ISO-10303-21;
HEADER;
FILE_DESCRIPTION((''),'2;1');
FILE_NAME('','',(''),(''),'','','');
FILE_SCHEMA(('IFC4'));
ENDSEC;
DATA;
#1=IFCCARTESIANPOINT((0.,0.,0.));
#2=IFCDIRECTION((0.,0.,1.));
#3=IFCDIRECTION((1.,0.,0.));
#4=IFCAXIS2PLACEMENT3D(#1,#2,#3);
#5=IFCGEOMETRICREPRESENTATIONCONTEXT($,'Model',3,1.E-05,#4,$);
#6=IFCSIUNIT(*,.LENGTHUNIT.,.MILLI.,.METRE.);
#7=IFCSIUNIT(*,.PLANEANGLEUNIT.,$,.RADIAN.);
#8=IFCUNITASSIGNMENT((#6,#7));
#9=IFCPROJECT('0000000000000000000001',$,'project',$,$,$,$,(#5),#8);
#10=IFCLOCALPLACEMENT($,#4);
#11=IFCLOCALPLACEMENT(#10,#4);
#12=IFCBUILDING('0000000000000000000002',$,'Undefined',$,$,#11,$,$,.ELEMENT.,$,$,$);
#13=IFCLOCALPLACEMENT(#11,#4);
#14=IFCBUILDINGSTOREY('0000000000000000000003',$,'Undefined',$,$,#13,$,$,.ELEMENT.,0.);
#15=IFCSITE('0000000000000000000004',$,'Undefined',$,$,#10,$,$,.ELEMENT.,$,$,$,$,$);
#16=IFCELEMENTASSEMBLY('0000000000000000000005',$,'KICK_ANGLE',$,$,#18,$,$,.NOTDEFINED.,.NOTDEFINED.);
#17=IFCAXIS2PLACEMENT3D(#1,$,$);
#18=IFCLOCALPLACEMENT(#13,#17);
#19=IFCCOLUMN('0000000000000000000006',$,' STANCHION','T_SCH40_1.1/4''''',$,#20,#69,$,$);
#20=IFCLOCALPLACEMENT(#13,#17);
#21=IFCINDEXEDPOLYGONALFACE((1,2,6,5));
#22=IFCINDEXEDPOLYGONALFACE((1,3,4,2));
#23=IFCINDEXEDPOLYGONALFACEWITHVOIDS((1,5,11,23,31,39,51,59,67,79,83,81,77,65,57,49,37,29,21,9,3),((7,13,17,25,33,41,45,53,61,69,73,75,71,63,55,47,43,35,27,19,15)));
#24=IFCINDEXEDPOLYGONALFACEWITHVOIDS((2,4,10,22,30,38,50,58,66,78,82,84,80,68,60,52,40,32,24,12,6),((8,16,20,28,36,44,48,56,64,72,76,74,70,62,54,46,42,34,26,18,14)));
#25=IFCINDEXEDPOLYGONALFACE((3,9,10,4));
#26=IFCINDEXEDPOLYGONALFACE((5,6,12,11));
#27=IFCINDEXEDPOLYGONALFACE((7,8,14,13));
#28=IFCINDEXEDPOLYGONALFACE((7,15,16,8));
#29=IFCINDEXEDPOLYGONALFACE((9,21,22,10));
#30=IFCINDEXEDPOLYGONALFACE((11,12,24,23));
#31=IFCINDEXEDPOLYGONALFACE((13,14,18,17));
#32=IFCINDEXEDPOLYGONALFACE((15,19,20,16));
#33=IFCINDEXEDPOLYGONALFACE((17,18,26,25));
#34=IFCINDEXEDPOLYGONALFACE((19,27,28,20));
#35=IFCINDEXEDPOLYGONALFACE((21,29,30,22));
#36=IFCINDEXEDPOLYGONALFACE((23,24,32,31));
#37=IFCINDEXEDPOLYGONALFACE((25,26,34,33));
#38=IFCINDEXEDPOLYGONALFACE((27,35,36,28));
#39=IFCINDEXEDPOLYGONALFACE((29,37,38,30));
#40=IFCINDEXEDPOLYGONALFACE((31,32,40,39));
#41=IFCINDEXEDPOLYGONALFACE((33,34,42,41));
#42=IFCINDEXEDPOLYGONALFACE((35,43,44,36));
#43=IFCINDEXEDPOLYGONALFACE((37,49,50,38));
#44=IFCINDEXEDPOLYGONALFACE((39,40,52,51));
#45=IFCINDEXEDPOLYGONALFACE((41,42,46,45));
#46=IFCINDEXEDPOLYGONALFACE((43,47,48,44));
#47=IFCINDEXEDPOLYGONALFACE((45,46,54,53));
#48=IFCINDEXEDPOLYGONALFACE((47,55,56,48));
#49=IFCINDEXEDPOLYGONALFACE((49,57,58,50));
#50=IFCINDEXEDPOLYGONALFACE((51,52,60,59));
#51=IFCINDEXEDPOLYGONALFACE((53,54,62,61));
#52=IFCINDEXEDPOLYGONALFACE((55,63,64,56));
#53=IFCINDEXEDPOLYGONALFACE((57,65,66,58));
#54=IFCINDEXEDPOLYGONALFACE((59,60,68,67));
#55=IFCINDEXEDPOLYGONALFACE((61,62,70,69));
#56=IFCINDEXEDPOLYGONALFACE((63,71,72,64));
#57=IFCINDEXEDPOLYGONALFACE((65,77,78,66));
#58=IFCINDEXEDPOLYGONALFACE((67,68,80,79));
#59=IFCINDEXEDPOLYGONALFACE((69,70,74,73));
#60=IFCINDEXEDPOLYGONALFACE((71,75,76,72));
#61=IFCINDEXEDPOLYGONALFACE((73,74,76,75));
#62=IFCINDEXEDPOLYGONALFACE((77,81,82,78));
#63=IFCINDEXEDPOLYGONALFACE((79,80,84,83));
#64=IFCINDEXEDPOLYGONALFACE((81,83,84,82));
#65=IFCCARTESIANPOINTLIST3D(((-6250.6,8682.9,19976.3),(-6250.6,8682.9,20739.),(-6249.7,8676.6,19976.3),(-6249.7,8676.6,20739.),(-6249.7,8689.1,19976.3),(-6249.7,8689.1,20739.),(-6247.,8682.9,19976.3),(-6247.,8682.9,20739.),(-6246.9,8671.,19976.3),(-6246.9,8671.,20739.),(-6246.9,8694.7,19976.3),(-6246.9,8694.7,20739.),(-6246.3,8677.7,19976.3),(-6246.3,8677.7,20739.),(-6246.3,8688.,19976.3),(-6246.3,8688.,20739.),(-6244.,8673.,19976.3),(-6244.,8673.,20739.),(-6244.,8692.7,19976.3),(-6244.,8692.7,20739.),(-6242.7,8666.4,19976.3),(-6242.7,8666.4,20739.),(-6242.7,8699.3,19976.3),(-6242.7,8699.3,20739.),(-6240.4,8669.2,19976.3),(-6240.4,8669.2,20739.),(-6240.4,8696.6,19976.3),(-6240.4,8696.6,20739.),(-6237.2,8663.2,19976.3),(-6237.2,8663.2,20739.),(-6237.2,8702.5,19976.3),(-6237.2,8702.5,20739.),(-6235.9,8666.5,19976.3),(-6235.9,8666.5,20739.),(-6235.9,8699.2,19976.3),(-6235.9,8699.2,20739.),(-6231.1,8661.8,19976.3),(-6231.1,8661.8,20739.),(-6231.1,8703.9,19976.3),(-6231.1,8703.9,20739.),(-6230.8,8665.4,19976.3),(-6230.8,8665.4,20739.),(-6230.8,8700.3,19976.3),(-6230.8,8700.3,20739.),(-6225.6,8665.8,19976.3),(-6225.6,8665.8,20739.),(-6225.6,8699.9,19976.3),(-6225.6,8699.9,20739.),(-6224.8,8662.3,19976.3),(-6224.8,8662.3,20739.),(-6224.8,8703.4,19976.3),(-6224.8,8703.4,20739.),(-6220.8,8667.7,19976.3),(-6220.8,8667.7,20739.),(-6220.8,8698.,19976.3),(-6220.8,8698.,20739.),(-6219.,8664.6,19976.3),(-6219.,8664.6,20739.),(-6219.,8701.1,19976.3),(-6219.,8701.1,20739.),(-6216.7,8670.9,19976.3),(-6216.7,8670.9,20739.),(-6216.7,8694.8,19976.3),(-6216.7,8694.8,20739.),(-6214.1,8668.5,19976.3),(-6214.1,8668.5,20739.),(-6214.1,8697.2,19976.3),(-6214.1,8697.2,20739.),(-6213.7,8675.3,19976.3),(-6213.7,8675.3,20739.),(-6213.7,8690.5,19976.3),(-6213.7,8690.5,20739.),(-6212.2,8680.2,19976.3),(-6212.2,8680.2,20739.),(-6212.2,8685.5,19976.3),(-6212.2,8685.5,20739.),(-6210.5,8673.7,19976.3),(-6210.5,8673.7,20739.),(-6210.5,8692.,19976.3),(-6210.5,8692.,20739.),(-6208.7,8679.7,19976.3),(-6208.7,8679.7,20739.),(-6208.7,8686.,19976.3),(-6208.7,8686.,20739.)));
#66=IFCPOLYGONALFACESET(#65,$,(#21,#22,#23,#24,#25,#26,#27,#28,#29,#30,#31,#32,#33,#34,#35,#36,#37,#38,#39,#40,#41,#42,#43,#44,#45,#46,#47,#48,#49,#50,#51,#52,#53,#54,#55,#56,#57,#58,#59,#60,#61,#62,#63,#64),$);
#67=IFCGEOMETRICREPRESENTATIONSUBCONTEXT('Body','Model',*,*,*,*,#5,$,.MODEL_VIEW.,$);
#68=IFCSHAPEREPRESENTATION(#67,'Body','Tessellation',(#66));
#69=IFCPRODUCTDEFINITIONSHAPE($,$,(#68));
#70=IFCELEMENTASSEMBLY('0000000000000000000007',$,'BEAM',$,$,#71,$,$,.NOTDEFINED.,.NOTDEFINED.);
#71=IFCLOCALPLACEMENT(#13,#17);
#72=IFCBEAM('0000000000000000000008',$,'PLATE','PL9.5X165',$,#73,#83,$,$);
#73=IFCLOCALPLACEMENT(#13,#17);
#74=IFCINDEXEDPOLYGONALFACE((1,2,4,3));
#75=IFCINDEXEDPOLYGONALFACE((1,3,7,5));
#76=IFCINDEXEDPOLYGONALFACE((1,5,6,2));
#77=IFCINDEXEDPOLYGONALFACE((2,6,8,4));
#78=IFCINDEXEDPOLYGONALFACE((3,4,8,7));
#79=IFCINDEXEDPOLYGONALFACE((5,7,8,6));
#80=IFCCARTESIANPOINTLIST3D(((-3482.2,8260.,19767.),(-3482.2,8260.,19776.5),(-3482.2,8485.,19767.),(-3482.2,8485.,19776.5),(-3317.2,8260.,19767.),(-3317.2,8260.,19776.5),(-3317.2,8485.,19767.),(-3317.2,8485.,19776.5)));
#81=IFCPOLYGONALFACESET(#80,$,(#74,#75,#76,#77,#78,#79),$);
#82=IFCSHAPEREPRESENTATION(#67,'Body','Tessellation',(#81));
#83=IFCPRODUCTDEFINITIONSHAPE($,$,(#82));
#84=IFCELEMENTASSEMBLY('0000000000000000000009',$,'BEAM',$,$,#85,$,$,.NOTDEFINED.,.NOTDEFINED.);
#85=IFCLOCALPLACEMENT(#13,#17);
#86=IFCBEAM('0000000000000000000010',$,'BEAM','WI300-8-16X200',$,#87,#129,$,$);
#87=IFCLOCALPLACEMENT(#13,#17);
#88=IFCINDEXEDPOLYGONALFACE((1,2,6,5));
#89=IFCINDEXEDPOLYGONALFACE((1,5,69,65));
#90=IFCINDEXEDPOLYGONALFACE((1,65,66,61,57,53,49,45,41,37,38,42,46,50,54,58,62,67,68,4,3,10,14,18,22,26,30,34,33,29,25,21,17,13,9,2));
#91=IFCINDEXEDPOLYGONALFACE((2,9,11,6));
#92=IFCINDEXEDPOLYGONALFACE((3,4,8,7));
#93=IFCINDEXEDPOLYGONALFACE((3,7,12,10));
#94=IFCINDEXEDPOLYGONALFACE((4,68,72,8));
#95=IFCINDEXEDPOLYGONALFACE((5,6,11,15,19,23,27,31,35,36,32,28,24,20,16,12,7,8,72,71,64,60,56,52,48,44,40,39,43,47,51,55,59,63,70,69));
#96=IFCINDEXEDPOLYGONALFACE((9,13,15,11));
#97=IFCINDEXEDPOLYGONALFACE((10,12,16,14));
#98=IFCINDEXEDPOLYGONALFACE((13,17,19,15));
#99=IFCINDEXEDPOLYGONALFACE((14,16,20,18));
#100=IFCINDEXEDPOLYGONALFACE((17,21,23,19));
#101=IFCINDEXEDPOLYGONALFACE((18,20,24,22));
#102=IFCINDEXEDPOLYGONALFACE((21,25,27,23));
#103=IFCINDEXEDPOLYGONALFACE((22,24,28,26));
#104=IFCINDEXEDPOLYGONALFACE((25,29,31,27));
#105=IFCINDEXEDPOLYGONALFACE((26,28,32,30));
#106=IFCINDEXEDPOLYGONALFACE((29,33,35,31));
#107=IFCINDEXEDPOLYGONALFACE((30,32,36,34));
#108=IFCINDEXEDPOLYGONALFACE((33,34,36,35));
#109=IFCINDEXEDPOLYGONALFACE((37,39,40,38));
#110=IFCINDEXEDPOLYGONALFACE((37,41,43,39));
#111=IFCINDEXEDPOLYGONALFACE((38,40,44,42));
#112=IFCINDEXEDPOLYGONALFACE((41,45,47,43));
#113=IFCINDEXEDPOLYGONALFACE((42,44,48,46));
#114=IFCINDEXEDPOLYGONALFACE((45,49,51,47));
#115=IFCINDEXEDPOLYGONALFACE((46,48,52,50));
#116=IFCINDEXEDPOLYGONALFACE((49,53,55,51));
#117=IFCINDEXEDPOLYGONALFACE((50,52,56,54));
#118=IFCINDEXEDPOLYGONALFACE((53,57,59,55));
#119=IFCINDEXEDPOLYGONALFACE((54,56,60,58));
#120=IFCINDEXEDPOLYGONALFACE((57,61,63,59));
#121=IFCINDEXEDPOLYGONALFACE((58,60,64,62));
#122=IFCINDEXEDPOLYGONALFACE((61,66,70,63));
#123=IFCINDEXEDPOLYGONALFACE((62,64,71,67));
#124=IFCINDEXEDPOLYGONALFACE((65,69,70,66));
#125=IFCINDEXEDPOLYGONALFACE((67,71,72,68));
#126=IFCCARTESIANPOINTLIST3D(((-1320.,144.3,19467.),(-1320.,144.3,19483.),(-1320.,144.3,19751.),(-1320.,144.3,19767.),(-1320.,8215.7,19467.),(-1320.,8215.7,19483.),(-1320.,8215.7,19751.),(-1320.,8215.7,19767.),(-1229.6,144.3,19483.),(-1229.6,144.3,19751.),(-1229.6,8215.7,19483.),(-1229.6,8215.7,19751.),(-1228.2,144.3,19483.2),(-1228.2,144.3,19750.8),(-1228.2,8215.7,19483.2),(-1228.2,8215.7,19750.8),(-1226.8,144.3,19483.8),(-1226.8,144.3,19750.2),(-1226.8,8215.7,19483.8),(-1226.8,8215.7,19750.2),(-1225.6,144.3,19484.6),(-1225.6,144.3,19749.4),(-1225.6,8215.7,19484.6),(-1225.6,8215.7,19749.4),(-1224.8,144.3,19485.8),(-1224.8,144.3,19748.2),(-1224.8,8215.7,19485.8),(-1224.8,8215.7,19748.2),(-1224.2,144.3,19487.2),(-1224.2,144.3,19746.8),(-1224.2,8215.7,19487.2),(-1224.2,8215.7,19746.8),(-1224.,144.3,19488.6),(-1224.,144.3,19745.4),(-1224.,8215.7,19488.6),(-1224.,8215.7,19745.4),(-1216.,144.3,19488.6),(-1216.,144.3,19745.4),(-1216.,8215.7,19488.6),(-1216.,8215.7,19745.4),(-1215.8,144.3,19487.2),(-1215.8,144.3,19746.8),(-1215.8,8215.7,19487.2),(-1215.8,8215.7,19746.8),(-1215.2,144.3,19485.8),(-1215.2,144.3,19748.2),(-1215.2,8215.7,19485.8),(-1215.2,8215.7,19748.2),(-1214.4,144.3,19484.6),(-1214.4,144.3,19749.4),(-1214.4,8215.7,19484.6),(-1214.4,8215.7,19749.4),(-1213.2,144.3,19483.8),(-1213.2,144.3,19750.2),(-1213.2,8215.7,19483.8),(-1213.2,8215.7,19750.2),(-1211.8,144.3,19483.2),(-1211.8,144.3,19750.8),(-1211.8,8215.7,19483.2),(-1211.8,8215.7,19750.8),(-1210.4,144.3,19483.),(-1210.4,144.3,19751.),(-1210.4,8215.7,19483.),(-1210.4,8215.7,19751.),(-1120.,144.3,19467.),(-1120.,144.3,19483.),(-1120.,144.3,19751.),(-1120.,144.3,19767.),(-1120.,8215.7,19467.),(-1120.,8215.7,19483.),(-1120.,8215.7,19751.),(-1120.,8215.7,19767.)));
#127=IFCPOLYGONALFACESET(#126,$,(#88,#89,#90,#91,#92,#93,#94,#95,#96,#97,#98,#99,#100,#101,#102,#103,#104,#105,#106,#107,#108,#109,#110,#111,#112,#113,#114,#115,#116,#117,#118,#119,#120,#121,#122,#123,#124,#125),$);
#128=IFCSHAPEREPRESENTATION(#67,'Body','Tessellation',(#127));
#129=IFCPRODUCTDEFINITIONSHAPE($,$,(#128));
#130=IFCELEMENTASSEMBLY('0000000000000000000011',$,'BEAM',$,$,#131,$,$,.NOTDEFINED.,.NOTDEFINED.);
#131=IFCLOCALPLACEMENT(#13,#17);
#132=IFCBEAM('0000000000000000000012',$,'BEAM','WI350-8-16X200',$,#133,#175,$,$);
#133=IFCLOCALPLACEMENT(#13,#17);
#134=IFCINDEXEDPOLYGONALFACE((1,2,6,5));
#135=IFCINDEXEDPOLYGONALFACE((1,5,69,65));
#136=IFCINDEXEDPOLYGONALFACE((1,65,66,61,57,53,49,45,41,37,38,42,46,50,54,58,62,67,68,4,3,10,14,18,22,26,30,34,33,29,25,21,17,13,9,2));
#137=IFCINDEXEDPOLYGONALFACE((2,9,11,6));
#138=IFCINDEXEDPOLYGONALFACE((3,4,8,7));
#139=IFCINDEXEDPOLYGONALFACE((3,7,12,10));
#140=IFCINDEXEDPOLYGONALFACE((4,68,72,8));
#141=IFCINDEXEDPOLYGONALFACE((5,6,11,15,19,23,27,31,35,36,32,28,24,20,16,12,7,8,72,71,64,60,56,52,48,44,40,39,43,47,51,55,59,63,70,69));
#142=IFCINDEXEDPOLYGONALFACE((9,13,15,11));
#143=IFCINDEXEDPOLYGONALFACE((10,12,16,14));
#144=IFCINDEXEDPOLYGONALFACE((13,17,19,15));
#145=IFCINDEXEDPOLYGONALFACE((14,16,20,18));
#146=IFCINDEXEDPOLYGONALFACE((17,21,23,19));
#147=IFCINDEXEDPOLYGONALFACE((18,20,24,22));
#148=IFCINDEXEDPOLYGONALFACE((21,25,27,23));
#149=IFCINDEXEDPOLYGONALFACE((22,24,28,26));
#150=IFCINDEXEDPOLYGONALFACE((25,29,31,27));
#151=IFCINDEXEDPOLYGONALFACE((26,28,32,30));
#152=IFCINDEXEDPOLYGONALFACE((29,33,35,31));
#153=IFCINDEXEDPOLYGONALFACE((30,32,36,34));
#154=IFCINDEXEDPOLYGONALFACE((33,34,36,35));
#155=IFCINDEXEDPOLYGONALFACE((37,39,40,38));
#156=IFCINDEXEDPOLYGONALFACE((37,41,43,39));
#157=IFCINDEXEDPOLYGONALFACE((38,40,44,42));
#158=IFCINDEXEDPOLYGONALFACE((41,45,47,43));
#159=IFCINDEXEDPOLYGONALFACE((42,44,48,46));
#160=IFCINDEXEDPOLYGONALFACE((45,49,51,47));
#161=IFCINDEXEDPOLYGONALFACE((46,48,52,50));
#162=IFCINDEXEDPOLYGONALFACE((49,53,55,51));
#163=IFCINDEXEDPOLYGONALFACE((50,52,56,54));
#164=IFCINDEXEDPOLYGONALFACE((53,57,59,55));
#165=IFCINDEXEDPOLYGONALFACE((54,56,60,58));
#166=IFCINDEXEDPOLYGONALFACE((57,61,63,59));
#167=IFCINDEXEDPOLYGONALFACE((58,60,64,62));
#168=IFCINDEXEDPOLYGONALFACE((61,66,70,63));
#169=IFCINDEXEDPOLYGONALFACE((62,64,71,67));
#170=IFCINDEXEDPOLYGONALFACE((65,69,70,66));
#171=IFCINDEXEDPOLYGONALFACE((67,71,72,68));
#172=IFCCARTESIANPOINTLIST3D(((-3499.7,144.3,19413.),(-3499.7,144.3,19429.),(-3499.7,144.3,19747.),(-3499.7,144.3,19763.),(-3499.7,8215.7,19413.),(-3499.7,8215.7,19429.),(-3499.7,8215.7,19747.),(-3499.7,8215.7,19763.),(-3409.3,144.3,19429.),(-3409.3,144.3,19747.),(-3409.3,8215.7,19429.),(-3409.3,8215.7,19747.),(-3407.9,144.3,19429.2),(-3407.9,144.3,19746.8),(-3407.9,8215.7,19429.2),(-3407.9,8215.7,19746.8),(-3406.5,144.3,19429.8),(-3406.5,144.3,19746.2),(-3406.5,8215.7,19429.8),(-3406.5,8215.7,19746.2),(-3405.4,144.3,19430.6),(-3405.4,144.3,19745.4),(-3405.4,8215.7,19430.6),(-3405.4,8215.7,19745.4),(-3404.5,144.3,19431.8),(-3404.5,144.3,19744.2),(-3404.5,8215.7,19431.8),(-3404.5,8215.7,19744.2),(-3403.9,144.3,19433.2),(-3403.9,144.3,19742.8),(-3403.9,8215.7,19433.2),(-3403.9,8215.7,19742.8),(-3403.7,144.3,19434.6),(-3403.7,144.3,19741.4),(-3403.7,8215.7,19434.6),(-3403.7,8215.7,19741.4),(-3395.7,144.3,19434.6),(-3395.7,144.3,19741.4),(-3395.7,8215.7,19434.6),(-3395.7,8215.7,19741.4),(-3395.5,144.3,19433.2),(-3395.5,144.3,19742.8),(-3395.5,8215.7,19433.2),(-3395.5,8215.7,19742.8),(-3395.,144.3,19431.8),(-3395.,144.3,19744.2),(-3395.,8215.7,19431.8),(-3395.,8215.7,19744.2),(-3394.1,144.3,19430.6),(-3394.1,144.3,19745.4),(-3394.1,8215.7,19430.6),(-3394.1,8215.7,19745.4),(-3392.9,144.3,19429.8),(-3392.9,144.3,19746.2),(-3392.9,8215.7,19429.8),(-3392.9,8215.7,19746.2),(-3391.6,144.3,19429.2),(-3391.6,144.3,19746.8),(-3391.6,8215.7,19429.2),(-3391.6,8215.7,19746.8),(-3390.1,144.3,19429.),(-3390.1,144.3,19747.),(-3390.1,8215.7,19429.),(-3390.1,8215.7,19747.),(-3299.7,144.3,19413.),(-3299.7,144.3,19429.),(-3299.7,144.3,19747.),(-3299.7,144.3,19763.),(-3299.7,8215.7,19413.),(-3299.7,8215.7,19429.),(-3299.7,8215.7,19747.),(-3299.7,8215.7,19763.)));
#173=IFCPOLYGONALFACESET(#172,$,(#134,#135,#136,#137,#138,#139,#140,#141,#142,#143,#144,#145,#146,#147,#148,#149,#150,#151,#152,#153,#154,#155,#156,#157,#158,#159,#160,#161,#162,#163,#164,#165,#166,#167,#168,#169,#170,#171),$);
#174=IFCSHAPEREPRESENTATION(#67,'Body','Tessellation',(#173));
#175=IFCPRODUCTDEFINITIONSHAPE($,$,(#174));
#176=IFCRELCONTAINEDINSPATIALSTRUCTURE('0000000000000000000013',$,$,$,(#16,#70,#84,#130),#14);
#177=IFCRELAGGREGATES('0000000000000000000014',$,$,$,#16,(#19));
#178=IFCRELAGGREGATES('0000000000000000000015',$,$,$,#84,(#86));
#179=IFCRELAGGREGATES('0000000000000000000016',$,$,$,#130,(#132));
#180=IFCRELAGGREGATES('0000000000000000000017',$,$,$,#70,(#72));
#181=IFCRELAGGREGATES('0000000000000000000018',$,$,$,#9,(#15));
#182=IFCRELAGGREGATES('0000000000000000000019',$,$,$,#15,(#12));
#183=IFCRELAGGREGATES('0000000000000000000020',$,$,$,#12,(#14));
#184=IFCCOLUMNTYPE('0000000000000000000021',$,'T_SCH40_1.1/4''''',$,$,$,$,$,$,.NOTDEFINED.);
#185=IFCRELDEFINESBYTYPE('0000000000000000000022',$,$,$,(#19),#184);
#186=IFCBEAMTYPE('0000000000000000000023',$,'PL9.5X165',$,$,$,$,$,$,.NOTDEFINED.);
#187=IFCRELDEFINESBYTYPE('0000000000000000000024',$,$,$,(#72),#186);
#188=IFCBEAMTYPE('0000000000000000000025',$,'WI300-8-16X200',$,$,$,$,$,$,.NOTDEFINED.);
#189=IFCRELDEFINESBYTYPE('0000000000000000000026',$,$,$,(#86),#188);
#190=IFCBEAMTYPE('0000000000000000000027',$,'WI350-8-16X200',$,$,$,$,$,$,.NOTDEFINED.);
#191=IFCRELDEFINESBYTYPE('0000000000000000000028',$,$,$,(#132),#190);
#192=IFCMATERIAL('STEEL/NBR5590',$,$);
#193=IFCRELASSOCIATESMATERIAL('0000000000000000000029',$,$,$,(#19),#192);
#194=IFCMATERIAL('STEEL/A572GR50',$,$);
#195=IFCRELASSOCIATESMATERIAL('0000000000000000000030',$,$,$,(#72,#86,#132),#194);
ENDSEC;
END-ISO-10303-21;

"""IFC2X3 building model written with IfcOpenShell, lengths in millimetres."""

from ifc_helpers import new_model, si_unit, frame, origin_with_axes, origin_2d_with_axis, place, context, subcontext, project, spatial, rectangle, hollow_circle, i_section, extrude, clip, halfspace, material, type_object, element, aggregate, save


model = new_model("IFC2X3")

# Units and contexts
model_context = context("Model", 3, precision=1e-05, world=origin_with_axes())
body_context = subcontext(model_context, "Body", "Model", "MODEL_VIEW")
ifc_project = project(units=[si_unit("LENGTHUNIT", "METRE", prefix="MILLI"), si_unit("PLANEANGLEUNIT", "RADIAN")], contexts=[model_context])

# Site, building, storey
site_placement = place(None, origin_with_axes())
site = spatial("IfcSite", under=ifc_project, at=site_placement, Name="Undefined", CompositionType="ELEMENT")
building_placement = place(site_placement, origin_with_axes())
building = spatial("IfcBuilding", under=site, at=building_placement, Name="Undefined", CompositionType="ELEMENT")
storey_placement = place(building_placement, origin_with_axes())
storey = spatial("IfcBuildingStorey", under=building, at=storey_placement, Name="Undefined", CompositionType="ELEMENT", Elevation=0.0)

# Element assembly, column
assembly_1_placement = place(storey_placement, origin_with_axes())
assembly_1 = element("IfcElementAssembly", 1, at=assembly_1_placement, inside=storey, Name="KICK_ANGLE", AssemblyPlace="NOTDEFINED", PredefinedType="NOTDEFINED")
ifc_material_1 = material(Name="STEEL/NBR5590")
column_type = type_object("IfcColumnType", Name="T_SCH40_1.1/4''", PredefinedType="NOTDEFINED")
column_placement = place(assembly_1_placement, frame((-6229.5, 8682.9, 19976.3), z_axis=(0.0, 0.0, 1.0), x_axis=(0.000006, 1.0, 0.0)))
column = element("IfcColumn", 2, at=column_placement, type_object=column_type, material=ifc_material_1, Name=" STANCHION", Description="T_SCH40_1.1/4''", context=body_context, shape_type="Clipping", body=[
    clip(extrude(hollow_circle(Radius=21.1, WallThickness=3.6, at=origin_2d_with_axis()), frame((0.0, 0.0, 1113.6), z_axis=(0.0, 0.0, -1.0), x_axis=(0.0, 1.0, 0.0)), (0.0, 0.0, 1.0), 1113.6), halfspace(frame((0.0, 0.0, 762.7), z_axis=(0.0, 0.0, 1.0), x_axis=(0.0, 1.0, 0.0)), False)),
])
aggregate(assembly_1, [column])

# Element assemblies, beams
assembly_2_placement = place(storey_placement, origin_with_axes())
assembly_2 = element("IfcElementAssembly", 3, at=assembly_2_placement, inside=storey, Name="BEAM", AssemblyPlace="NOTDEFINED", PredefinedType="NOTDEFINED")
ifc_material_2 = material(Name="STEEL/A572GR50")
beam_type_1 = type_object("IfcBeamType", Name="PL9.5X165", PredefinedType="NOTDEFINED")
beam_1_placement = place(assembly_2_placement, frame((-3399.7, 8260.0, 19771.8), z_axis=(1.0, 0.0, 0.0), x_axis=(0.0, 1.0, 0.0)))
beam_1 = element("IfcBeam", 4, at=beam_1_placement, type_object=beam_type_1, material=ifc_material_2, Name="PLATE", Description="PL9.5X165", context=body_context, shape_type="SweptSolid", body=[
    extrude(rectangle(XDim=9.5, YDim=165.0, at=origin_2d_with_axis()), frame((225.0, 0.0, 0.0), z_axis=(-1.0, 0.0, 0.0), x_axis=(0.0, -1.0, 0.0)), (0.0, 0.0, 1.0), 225.0),
])
assembly_3_placement = place(storey_placement, origin_with_axes())
assembly_3 = element("IfcElementAssembly", 5, at=assembly_3_placement, inside=storey, Name="BEAM", AssemblyPlace="NOTDEFINED", PredefinedType="NOTDEFINED")
beam_type_2 = type_object("IfcBeamType", Name="WI300-8-16X200", PredefinedType="NOTDEFINED")
beam_2_placement = place(assembly_3_placement, frame((-1220.0, 8360.0, 19617.0), z_axis=(0.0, 0.0, 1.0), x_axis=(0.0, -1.0, 0.0)))
beam_2 = element("IfcBeam", 6, at=beam_2_placement, type_object=beam_type_2, material=ifc_material_2, Name="BEAM", Description="WI300-8-16X200", context=body_context, shape_type="Clipping", body=[
    clip(clip(extrude(i_section(OverallWidth=200.0, OverallDepth=300.0, WebThickness=8.0, FlangeThickness=16.0, FilletRadius=5.6, at=origin_2d_with_axis()), frame((8360.0, 0.0, 0.0), z_axis=(-1.0, 0.0, 0.0), x_axis=(0.0, -1.0, 0.0)), (0.0, 0.0, 1.0), 8360.0), halfspace(frame((8215.7, 0.0, -150.0), z_axis=(-1.0, 0.0, 0.0), x_axis=(0.0, 1.0, 0.0)), True)), halfspace(frame((144.3, 0.0, -150.0), z_axis=(1.0, 0.0, 0.0), x_axis=(0.0, -1.0, 0.0)), True)),
])
assembly_4_placement = place(storey_placement, origin_with_axes())
assembly_4 = element("IfcElementAssembly", 7, at=assembly_4_placement, inside=storey, Name="BEAM", AssemblyPlace="NOTDEFINED", PredefinedType="NOTDEFINED")
beam_type_3 = type_object("IfcBeamType", Name="WI350-8-16X200", PredefinedType="NOTDEFINED")
beam_3_placement = place(assembly_4_placement, frame((-3399.7, 8360.0, 19588.0), z_axis=(0.0, 0.0, 1.0), x_axis=(0.0, -1.0, 0.0)))
beam_3 = element("IfcBeam", 8, at=beam_3_placement, type_object=beam_type_3, material=ifc_material_2, Name="BEAM", Description="WI350-8-16X200", context=body_context, shape_type="Clipping", body=[
    clip(clip(extrude(i_section(OverallWidth=200.0, OverallDepth=350.0, WebThickness=8.0, FlangeThickness=16.0, FilletRadius=5.6, at=origin_2d_with_axis()), frame((8360.0, 0.0, 0.0), z_axis=(-1.0, 0.0, 0.0), x_axis=(0.0, -1.0, 0.0)), (0.0, 0.0, 1.0), 8360.0), halfspace(frame((8215.7, 0.0, -175.0), z_axis=(-1.0, 0.0, 0.0), x_axis=(0.0, 1.0, 0.0)), True)), halfspace(frame((144.3, 0.0, -175.0), z_axis=(1.0, 0.0, 0.0), x_axis=(0.0, -1.0, 0.0)), True)),
])

aggregate(assembly_3, [beam_2])
aggregate(assembly_4, [beam_3])
aggregate(assembly_2, [beam_1])

save(model, "model.ifc")
